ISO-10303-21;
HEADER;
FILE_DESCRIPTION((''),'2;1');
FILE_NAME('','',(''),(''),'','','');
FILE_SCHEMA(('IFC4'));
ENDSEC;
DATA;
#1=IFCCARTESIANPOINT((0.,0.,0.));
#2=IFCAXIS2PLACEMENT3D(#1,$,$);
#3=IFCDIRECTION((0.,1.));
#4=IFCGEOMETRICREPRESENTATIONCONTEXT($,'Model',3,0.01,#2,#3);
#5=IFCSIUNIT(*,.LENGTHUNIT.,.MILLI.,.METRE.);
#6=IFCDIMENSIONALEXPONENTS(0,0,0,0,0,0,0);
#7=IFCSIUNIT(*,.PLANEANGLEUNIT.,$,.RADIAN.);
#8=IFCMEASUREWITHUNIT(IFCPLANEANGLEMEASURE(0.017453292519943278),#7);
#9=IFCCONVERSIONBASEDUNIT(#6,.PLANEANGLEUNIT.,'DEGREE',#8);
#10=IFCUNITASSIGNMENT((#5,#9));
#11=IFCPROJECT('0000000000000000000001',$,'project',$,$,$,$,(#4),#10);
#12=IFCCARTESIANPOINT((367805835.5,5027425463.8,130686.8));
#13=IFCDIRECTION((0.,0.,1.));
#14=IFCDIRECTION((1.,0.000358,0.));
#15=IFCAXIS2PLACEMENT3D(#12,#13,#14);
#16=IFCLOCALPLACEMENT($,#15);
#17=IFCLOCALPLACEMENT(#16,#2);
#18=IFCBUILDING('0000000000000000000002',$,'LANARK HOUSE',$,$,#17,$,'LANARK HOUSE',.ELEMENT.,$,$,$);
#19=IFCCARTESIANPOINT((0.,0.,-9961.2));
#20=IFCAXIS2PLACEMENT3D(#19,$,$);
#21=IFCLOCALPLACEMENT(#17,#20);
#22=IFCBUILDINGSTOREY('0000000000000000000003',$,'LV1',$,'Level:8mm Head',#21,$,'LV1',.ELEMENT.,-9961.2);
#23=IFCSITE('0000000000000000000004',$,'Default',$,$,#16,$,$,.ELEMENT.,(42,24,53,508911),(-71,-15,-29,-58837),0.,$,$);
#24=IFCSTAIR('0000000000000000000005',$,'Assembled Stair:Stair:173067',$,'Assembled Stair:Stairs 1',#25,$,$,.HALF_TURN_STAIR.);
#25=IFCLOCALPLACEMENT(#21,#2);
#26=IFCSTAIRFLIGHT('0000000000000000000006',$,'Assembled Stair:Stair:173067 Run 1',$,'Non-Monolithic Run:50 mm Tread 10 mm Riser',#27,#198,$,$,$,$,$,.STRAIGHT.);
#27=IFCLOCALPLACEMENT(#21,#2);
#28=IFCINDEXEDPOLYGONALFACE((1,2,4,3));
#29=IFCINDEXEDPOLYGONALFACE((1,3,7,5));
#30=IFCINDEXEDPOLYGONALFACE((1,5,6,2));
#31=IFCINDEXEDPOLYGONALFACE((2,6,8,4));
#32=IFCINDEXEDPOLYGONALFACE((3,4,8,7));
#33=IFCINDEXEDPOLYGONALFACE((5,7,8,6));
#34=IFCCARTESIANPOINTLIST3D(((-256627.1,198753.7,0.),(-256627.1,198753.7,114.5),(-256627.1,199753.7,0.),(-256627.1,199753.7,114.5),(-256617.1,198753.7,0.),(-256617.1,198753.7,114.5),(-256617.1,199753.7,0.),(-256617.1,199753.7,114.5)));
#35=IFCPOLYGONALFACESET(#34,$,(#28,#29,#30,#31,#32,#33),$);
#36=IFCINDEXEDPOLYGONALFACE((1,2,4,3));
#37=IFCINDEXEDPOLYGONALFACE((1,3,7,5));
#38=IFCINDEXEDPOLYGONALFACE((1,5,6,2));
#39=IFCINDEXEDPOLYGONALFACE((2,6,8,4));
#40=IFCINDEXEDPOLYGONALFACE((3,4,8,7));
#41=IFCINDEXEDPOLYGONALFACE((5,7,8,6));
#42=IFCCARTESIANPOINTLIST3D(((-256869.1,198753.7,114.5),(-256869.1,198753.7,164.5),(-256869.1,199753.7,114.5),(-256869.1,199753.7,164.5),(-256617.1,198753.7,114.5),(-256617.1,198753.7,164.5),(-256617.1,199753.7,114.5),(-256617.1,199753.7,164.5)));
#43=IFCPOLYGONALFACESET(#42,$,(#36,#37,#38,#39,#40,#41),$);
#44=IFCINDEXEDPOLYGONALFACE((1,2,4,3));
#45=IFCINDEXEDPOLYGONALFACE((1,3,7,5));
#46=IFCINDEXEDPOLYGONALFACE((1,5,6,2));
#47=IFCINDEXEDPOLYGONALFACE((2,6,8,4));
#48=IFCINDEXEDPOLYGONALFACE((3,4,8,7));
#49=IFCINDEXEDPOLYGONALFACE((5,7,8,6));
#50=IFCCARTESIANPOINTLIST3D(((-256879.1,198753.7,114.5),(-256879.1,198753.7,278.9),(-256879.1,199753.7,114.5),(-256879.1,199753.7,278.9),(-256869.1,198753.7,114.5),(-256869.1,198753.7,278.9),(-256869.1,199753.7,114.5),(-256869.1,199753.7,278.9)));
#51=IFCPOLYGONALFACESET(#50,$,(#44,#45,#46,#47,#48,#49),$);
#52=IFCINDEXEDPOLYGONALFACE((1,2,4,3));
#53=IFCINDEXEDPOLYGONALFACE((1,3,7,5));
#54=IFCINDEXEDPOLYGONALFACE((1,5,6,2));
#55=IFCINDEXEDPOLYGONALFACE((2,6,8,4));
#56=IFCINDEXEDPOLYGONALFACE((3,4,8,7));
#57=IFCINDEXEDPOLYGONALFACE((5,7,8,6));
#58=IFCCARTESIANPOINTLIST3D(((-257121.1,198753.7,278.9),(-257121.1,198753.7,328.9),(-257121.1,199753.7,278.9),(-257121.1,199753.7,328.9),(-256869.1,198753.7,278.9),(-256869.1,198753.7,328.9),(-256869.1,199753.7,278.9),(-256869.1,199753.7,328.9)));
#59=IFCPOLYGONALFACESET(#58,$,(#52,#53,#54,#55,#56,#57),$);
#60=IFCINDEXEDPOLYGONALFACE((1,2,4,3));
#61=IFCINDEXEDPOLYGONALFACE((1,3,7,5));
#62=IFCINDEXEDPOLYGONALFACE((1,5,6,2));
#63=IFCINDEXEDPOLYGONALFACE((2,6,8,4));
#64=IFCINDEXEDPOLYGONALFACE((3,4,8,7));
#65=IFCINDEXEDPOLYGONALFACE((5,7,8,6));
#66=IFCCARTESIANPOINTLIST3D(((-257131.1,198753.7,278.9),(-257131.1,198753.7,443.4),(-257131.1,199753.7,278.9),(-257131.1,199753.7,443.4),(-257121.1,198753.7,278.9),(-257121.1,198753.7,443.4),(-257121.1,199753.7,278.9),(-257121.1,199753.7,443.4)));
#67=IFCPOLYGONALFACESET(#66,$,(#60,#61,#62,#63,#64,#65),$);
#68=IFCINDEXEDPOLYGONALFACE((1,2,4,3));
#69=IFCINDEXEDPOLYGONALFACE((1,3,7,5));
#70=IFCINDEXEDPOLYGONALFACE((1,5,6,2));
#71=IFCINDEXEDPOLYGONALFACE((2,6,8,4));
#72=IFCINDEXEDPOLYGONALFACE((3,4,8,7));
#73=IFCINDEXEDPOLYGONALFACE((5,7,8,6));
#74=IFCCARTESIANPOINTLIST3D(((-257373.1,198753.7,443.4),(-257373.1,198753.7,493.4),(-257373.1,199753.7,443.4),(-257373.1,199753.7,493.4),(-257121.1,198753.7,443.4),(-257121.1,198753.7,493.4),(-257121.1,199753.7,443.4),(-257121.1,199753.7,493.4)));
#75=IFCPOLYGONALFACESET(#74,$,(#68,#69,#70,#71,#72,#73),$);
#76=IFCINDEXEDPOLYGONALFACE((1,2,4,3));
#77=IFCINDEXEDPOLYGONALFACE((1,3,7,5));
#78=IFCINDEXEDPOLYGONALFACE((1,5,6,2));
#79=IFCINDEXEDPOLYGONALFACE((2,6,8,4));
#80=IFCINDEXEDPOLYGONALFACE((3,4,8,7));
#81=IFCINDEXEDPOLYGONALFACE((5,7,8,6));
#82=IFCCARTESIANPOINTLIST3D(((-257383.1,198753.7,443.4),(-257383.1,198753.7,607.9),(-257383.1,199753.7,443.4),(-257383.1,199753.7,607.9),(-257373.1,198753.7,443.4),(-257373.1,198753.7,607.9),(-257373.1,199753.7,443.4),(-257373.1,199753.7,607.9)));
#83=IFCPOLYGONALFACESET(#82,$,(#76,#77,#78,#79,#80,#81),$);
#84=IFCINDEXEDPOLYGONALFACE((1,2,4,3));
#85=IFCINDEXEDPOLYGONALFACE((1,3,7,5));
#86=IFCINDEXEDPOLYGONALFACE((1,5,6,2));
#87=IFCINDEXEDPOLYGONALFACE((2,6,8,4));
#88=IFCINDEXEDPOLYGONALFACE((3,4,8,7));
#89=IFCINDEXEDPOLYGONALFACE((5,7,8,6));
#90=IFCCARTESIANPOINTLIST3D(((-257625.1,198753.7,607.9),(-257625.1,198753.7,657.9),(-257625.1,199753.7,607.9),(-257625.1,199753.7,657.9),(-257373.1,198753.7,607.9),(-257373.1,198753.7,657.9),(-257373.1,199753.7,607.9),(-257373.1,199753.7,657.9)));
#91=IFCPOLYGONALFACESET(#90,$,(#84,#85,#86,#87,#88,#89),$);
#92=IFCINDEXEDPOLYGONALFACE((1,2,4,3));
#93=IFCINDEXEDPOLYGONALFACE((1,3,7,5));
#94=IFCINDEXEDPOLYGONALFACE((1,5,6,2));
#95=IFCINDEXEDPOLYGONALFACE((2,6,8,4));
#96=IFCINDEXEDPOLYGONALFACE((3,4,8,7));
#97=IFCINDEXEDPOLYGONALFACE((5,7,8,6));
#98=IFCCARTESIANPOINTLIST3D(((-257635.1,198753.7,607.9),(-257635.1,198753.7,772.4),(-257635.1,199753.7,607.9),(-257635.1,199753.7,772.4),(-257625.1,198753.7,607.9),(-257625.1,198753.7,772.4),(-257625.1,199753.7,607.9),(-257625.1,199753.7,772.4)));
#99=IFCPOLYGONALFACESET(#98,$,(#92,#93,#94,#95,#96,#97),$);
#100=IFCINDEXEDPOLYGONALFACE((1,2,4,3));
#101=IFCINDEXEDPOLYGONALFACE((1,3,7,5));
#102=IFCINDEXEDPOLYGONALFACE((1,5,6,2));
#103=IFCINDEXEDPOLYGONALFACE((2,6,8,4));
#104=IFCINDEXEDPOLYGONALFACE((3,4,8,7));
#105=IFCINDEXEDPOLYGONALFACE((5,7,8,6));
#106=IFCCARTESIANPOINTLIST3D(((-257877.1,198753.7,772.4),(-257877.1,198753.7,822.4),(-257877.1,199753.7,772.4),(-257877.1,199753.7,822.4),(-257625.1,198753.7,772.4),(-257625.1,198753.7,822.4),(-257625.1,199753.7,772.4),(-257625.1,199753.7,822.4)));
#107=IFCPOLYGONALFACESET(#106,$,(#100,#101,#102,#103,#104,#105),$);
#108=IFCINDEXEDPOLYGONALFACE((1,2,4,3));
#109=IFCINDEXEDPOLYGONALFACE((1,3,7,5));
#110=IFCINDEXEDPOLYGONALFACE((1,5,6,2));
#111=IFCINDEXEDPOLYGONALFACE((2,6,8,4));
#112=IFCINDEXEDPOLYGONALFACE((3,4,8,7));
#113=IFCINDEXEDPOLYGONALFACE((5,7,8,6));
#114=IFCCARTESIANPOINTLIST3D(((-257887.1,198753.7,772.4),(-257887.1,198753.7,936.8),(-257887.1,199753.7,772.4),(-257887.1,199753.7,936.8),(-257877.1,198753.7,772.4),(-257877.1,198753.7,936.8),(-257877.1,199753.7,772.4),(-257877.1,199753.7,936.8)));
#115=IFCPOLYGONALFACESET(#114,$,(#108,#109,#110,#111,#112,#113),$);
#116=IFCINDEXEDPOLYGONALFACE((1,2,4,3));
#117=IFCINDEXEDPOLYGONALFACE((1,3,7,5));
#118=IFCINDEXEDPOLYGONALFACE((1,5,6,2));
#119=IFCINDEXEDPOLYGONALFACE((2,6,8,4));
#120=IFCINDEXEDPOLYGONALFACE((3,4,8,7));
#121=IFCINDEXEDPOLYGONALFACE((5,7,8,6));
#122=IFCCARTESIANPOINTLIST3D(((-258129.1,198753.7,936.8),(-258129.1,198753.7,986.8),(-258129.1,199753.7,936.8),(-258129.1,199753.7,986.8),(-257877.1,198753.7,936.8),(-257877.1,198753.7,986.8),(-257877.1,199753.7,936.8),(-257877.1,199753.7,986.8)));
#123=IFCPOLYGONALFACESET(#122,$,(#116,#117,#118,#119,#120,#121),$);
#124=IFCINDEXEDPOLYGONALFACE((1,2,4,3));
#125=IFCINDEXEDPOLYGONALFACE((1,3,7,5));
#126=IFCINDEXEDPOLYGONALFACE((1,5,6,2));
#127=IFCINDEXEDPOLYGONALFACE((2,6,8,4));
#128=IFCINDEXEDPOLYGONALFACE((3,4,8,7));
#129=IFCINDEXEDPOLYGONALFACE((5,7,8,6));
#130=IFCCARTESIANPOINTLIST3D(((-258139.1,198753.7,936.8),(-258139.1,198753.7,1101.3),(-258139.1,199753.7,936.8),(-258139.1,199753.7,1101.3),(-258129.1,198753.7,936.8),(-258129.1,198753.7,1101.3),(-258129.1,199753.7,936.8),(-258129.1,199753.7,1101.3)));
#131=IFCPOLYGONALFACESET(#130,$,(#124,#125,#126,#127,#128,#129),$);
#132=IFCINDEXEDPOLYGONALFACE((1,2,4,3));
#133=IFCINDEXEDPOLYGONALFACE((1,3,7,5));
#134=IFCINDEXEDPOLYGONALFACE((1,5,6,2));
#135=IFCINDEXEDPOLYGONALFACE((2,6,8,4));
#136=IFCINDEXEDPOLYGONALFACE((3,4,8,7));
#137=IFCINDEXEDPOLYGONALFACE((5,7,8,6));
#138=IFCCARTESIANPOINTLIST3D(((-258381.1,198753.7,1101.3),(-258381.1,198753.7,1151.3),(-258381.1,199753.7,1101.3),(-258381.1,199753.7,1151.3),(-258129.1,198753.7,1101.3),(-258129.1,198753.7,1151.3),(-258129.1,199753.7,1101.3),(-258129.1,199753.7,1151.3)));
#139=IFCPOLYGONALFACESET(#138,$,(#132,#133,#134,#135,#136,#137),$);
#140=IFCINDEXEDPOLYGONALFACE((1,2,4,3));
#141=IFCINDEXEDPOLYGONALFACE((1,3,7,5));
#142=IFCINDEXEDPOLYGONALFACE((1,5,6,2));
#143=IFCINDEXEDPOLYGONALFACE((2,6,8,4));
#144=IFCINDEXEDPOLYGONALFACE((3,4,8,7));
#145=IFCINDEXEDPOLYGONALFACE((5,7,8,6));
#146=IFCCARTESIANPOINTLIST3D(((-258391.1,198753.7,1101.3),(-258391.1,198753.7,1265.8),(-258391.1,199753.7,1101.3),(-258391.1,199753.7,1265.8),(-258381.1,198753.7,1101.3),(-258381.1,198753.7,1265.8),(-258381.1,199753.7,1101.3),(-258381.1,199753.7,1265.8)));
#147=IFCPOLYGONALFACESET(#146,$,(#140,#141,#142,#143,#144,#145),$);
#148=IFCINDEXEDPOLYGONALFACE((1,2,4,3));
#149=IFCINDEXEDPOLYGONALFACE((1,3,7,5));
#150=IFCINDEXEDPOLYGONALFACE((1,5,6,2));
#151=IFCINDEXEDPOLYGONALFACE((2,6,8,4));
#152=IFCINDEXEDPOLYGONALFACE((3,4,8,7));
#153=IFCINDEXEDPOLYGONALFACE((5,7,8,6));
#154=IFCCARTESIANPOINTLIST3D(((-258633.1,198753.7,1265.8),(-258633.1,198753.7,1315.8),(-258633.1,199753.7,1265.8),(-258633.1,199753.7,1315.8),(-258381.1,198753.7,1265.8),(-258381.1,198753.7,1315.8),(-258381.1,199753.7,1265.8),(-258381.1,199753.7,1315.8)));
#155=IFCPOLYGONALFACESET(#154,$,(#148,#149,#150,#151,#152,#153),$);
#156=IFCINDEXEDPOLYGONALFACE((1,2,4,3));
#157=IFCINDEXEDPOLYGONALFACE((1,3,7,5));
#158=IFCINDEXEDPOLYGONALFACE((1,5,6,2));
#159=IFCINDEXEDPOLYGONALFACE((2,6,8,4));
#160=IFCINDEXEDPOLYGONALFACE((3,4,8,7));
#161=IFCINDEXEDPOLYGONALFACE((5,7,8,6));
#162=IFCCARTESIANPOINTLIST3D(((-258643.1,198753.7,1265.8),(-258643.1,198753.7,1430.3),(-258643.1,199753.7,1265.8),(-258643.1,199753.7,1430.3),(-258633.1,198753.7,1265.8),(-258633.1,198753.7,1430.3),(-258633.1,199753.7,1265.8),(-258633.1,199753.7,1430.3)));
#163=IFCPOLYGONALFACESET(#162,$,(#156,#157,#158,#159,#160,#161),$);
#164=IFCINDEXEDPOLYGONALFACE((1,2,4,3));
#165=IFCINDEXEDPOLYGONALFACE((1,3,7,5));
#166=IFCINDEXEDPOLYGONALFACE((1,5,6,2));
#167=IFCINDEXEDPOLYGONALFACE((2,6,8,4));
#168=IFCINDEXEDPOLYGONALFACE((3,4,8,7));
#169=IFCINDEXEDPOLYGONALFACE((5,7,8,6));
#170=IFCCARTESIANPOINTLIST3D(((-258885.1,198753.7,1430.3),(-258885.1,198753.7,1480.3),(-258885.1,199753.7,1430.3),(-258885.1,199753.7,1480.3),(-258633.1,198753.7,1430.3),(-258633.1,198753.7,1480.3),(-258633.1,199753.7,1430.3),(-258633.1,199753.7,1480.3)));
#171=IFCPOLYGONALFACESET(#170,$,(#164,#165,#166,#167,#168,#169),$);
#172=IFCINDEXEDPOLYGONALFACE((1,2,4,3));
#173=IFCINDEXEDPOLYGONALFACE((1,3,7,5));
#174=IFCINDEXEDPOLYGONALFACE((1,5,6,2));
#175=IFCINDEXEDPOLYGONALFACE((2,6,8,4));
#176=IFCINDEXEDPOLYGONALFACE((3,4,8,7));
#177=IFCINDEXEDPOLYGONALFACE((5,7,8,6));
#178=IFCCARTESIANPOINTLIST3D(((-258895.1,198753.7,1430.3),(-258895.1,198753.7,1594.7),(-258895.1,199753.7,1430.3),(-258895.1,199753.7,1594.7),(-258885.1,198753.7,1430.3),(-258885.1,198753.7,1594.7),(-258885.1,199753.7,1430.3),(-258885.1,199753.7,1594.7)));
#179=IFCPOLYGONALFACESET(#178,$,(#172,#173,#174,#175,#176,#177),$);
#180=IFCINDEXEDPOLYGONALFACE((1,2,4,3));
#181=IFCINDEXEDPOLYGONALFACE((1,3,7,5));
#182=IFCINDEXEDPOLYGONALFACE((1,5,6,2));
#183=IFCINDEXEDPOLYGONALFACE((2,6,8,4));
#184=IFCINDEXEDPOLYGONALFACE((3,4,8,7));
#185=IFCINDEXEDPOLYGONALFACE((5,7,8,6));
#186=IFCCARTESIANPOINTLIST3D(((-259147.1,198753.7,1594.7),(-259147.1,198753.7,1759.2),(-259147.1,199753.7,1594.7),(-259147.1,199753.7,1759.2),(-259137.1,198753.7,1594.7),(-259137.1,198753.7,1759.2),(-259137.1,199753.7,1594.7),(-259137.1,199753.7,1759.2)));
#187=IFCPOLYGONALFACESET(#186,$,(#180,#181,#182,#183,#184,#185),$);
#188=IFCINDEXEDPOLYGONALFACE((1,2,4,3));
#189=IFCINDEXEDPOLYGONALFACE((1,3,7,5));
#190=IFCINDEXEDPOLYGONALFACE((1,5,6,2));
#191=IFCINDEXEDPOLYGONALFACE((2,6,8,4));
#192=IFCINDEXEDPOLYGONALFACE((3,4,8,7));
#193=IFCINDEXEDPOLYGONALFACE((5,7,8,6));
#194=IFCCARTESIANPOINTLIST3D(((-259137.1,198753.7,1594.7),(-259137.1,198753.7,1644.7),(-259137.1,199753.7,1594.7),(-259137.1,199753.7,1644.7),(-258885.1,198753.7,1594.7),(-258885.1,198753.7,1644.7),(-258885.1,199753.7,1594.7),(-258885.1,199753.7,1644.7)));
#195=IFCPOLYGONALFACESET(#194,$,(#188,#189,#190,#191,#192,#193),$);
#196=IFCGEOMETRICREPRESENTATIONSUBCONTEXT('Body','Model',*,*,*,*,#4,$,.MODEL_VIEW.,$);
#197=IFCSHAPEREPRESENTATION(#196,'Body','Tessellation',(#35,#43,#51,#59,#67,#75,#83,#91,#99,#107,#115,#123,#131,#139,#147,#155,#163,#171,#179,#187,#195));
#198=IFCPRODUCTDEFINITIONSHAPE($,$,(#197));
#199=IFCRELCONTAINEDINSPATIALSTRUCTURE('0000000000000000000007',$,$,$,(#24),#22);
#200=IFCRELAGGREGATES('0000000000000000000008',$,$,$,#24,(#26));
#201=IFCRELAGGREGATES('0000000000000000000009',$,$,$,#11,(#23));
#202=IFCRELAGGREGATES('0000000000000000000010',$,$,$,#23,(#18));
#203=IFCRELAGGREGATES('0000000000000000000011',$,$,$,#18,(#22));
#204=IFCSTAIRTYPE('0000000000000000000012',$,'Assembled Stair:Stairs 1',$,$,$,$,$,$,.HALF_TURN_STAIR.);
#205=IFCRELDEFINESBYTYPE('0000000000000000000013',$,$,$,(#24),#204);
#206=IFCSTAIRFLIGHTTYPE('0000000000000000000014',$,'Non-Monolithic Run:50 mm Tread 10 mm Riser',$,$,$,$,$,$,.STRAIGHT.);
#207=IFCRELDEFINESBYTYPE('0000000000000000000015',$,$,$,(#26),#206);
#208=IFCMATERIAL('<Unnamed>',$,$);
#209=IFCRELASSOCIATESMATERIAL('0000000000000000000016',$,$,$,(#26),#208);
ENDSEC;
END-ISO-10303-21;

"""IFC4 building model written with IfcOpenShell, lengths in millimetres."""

from ifc_helpers import new_model, entity, si_unit, converted_unit, direction, frame, origin, place, context, subcontext, project, spatial, indexed_curve, outline, extrude, material, type_object, element, aggregate, save


model = new_model("IFC4")

# Units and contexts
model_context = context("Model", 3, precision=0.01, world=origin(), true_north=direction((0.0, 1.0)))
body_context = subcontext(model_context, "Body", "Model", "MODEL_VIEW")
ifc_project = project(units=[si_unit("LENGTHUNIT", "METRE", prefix="MILLI"), converted_unit("PLANEANGLEUNIT", "DEGREE", entity("IfcPlaneAngleMeasure", 0.017453292519943278), si_unit("PLANEANGLEUNIT", "RADIAN"), dimensions=[0, 0, 0, 0, 0, 0, 0])], contexts=[model_context])

# Site, building, storey
site_placement = place(None, frame((367805835.5, 5027425463.8, 130686.8), z_axis=(0.0, 0.0, 1.0), x_axis=(1.0, 0.000358, 0.0)))
site = spatial("IfcSite", under=ifc_project, at=site_placement, Name="Default", CompositionType="ELEMENT", RefLatitude=(42, 24, 53, 508911), RefLongitude=(-71, -15, -29, -58837), RefElevation=0.0)
building_placement = place(site_placement, origin())
building = spatial("IfcBuilding", under=site, at=building_placement, Name="LANARK HOUSE", LongName="LANARK HOUSE", CompositionType="ELEMENT")
storey_placement = place(building_placement, frame((0.0, 0.0, -9961.2)))
storey = spatial("IfcBuildingStorey", under=building, at=storey_placement, Name="LV1", ObjectType="Level:8mm Head", LongName="LV1", CompositionType="ELEMENT", Elevation=-9961.2)

# Stair
stair_type = type_object("IfcStairType", Name="Assembled Stair:Stairs 1", PredefinedType="HALF_TURN_STAIR")
stair_placement = place(storey_placement, origin())
stair = element("IfcStair", 1, at=stair_placement, inside=storey, type_object=stair_type, Name="Assembled Stair:Stair:173067", ObjectType="Assembled Stair:Stairs 1", PredefinedType="HALF_TURN_STAIR")
ifc_material_1 = material(Name="<Unnamed>")

# Stair flight
stair_flight_type = type_object("IfcStairFlightType", Name="Non-Monolithic Run:50 mm Tread 10 mm Riser", PredefinedType="STRAIGHT")
stair_flight_1_placement = place(stair_placement, frame((-259147.1, 198753.7, 0.0)))
stair_flight_1 = element("IfcStairFlight", 2, at=stair_flight_1_placement, type_object=stair_flight_type, material=ifc_material_1, Name="Assembled Stair:Stair:173067 Run 1", ObjectType="Non-Monolithic Run:50 mm Tread 10 mm Riser", PredefinedType="STRAIGHT", context=body_context, shape_type="SweptSolid", body=[
    extrude(outline(indexed_curve([(-500.0, -5.0), (500.0, -5.0), (500.0, 5.0), (-500.0, 5.0), (-500.0, -5.0)], self_intersect=False)), frame((2525.0, 500.0, 0.0), z_axis=(0.0, 0.0, 1.0), x_axis=(0.0, -1.0, 0.0)), (0.0, 0.0, 1.0), 114.5),
    extrude(outline(indexed_curve([(-126.0, -500.0), (126.0, -500.0), (126.0, 500.0), (-126.0, 500.0), (-126.0, -500.0)], self_intersect=False)), frame((2404.0, 500.0, 114.5)), (0.0, 0.0, 1.0), 50.0),
    extrude(outline(indexed_curve([(-500.0, -5.0), (500.0, -5.0), (500.0, 5.0), (-500.0, 5.0), (-500.0, -5.0)], self_intersect=False)), frame((2273.0, 500.0, 114.5), z_axis=(0.0, 0.0, 1.0), x_axis=(0.0, -1.0, 0.0)), (0.0, 0.0, 1.0), 164.5),
    extrude(outline(indexed_curve([(-126.0, -500.0), (126.0, -500.0), (126.0, 500.0), (-126.0, 500.0), (-126.0, -500.0)], self_intersect=False)), frame((2152.0, 500.0, 278.9)), (0.0, 0.0, 1.0), 50.0),
    extrude(outline(indexed_curve([(-500.0, -5.0), (500.0, -5.0), (500.0, 5.0), (-500.0, 5.0), (-500.0, -5.0)], self_intersect=False)), frame((2021.0, 500.0, 278.9), z_axis=(0.0, 0.0, 1.0), x_axis=(0.0, -1.0, 0.0)), (0.0, 0.0, 1.0), 164.5),
    extrude(outline(indexed_curve([(-126.0, -500.0), (126.0, -500.0), (126.0, 500.0), (-126.0, 500.0), (-126.0, -500.0)], self_intersect=False)), frame((1900.0, 500.0, 443.4)), (0.0, 0.0, 1.0), 50.0),
    extrude(outline(indexed_curve([(-500.0, -5.0), (500.0, -5.0), (500.0, 5.0), (-500.0, 5.0), (-500.0, -5.0)], self_intersect=False)), frame((1769.0, 500.0, 443.4), z_axis=(0.0, 0.0, 1.0), x_axis=(0.0, -1.0, 0.0)), (0.0, 0.0, 1.0), 164.5),
    extrude(outline(indexed_curve([(-126.0, -500.0), (126.0, -500.0), (126.0, 500.0), (-126.0, 500.0), (-126.0, -500.0)], self_intersect=False)), frame((1648.0, 500.0, 607.9)), (0.0, 0.0, 1.0), 50.0),
    extrude(outline(indexed_curve([(-500.0, -5.0), (500.0, -5.0), (500.0, 5.0), (-500.0, 5.0), (-500.0, -5.0)], self_intersect=False)), frame((1517.0, 500.0, 607.9), z_axis=(0.0, 0.0, 1.0), x_axis=(0.0, -1.0, 0.0)), (0.0, 0.0, 1.0), 164.5),
    extrude(outline(indexed_curve([(-126.0, -500.0), (126.0, -500.0), (126.0, 500.0), (-126.0, 500.0), (-126.0, -500.0)], self_intersect=False)), frame((1396.0, 500.0, 772.4)), (0.0, 0.0, 1.0), 50.0),
    extrude(outline(indexed_curve([(-500.0, -5.0), (500.0, -5.0), (500.0, 5.0), (-500.0, 5.0), (-500.0, -5.0)], self_intersect=False)), frame((1265.0, 500.0, 772.4), z_axis=(0.0, 0.0, 1.0), x_axis=(0.0, -1.0, 0.0)), (0.0, 0.0, 1.0), 164.5),
    extrude(outline(indexed_curve([(-126.0, -500.0), (126.0, -500.0), (126.0, 500.0), (-126.0, 500.0), (-126.0, -500.0)], self_intersect=False)), frame((1144.0, 500.0, 936.8)), (0.0, 0.0, 1.0), 50.0),
    extrude(outline(indexed_curve([(-500.0, -5.0), (500.0, -5.0), (500.0, 5.0), (-500.0, 5.0), (-500.0, -5.0)], self_intersect=False)), frame((1013.0, 500.0, 936.8), z_axis=(0.0, 0.0, 1.0), x_axis=(0.0, -1.0, 0.0)), (0.0, 0.0, 1.0), 164.5),
    extrude(outline(indexed_curve([(-126.0, -500.0), (126.0, -500.0), (126.0, 500.0), (-126.0, 500.0), (-126.0, -500.0)], self_intersect=False)), frame((892.0, 500.0, 1101.3)), (0.0, 0.0, 1.0), 50.0),
    extrude(outline(indexed_curve([(-500.0, -5.0), (500.0, -5.0), (500.0, 5.0), (-500.0, 5.0), (-500.0, -5.0)], self_intersect=False)), frame((761.0, 500.0, 1101.3), z_axis=(0.0, 0.0, 1.0), x_axis=(0.0, -1.0, 0.0)), (0.0, 0.0, 1.0), 164.5),
    extrude(outline(indexed_curve([(-126.0, -500.0), (126.0, -500.0), (126.0, 500.0), (-126.0, 500.0), (-126.0, -500.0)], self_intersect=False)), frame((640.0, 500.0, 1265.8)), (0.0, 0.0, 1.0), 50.0),
    extrude(outline(indexed_curve([(-500.0, -5.0), (500.0, -5.0), (500.0, 5.0), (-500.0, 5.0), (-500.0, -5.0)], self_intersect=False)), frame((509.0, 500.0, 1265.8), z_axis=(0.0, 0.0, 1.0), x_axis=(0.0, -1.0, 0.0)), (0.0, 0.0, 1.0), 164.5),
    extrude(outline(indexed_curve([(-126.0, -500.0), (126.0, -500.0), (126.0, 500.0), (-126.0, 500.0), (-126.0, -500.0)], self_intersect=False)), frame((388.0, 500.0, 1430.3)), (0.0, 0.0, 1.0), 50.0),
    extrude(outline(indexed_curve([(-500.0, -5.0), (500.0, -5.0), (500.0, 5.0), (-500.0, 5.0), (-500.0, -5.0)], self_intersect=False)), frame((257.0, 500.0, 1430.3), z_axis=(0.0, 0.0, 1.0), x_axis=(0.0, -1.0, 0.0)), (0.0, 0.0, 1.0), 164.5),
    extrude(outline(indexed_curve([(-500.0, -5.0), (500.0, -5.0), (500.0, 5.0), (-500.0, 5.0), (-500.0, -5.0)], self_intersect=False)), frame((5.0, 500.0, 1594.7), z_axis=(0.0, 0.0, 1.0), x_axis=(0.0, -1.0, 0.0)), (0.0, 0.0, 1.0), 164.5),
    extrude(outline(indexed_curve([(-126.0, -500.0), (126.0, -500.0), (126.0, 500.0), (-126.0, 500.0), (-126.0, -500.0)], self_intersect=False)), frame((136.0, 500.0, 1594.7)), (0.0, 0.0, 1.0), 50.0),
])

aggregate(stair, [stair_flight_1])

save(model, "model.ifc")
